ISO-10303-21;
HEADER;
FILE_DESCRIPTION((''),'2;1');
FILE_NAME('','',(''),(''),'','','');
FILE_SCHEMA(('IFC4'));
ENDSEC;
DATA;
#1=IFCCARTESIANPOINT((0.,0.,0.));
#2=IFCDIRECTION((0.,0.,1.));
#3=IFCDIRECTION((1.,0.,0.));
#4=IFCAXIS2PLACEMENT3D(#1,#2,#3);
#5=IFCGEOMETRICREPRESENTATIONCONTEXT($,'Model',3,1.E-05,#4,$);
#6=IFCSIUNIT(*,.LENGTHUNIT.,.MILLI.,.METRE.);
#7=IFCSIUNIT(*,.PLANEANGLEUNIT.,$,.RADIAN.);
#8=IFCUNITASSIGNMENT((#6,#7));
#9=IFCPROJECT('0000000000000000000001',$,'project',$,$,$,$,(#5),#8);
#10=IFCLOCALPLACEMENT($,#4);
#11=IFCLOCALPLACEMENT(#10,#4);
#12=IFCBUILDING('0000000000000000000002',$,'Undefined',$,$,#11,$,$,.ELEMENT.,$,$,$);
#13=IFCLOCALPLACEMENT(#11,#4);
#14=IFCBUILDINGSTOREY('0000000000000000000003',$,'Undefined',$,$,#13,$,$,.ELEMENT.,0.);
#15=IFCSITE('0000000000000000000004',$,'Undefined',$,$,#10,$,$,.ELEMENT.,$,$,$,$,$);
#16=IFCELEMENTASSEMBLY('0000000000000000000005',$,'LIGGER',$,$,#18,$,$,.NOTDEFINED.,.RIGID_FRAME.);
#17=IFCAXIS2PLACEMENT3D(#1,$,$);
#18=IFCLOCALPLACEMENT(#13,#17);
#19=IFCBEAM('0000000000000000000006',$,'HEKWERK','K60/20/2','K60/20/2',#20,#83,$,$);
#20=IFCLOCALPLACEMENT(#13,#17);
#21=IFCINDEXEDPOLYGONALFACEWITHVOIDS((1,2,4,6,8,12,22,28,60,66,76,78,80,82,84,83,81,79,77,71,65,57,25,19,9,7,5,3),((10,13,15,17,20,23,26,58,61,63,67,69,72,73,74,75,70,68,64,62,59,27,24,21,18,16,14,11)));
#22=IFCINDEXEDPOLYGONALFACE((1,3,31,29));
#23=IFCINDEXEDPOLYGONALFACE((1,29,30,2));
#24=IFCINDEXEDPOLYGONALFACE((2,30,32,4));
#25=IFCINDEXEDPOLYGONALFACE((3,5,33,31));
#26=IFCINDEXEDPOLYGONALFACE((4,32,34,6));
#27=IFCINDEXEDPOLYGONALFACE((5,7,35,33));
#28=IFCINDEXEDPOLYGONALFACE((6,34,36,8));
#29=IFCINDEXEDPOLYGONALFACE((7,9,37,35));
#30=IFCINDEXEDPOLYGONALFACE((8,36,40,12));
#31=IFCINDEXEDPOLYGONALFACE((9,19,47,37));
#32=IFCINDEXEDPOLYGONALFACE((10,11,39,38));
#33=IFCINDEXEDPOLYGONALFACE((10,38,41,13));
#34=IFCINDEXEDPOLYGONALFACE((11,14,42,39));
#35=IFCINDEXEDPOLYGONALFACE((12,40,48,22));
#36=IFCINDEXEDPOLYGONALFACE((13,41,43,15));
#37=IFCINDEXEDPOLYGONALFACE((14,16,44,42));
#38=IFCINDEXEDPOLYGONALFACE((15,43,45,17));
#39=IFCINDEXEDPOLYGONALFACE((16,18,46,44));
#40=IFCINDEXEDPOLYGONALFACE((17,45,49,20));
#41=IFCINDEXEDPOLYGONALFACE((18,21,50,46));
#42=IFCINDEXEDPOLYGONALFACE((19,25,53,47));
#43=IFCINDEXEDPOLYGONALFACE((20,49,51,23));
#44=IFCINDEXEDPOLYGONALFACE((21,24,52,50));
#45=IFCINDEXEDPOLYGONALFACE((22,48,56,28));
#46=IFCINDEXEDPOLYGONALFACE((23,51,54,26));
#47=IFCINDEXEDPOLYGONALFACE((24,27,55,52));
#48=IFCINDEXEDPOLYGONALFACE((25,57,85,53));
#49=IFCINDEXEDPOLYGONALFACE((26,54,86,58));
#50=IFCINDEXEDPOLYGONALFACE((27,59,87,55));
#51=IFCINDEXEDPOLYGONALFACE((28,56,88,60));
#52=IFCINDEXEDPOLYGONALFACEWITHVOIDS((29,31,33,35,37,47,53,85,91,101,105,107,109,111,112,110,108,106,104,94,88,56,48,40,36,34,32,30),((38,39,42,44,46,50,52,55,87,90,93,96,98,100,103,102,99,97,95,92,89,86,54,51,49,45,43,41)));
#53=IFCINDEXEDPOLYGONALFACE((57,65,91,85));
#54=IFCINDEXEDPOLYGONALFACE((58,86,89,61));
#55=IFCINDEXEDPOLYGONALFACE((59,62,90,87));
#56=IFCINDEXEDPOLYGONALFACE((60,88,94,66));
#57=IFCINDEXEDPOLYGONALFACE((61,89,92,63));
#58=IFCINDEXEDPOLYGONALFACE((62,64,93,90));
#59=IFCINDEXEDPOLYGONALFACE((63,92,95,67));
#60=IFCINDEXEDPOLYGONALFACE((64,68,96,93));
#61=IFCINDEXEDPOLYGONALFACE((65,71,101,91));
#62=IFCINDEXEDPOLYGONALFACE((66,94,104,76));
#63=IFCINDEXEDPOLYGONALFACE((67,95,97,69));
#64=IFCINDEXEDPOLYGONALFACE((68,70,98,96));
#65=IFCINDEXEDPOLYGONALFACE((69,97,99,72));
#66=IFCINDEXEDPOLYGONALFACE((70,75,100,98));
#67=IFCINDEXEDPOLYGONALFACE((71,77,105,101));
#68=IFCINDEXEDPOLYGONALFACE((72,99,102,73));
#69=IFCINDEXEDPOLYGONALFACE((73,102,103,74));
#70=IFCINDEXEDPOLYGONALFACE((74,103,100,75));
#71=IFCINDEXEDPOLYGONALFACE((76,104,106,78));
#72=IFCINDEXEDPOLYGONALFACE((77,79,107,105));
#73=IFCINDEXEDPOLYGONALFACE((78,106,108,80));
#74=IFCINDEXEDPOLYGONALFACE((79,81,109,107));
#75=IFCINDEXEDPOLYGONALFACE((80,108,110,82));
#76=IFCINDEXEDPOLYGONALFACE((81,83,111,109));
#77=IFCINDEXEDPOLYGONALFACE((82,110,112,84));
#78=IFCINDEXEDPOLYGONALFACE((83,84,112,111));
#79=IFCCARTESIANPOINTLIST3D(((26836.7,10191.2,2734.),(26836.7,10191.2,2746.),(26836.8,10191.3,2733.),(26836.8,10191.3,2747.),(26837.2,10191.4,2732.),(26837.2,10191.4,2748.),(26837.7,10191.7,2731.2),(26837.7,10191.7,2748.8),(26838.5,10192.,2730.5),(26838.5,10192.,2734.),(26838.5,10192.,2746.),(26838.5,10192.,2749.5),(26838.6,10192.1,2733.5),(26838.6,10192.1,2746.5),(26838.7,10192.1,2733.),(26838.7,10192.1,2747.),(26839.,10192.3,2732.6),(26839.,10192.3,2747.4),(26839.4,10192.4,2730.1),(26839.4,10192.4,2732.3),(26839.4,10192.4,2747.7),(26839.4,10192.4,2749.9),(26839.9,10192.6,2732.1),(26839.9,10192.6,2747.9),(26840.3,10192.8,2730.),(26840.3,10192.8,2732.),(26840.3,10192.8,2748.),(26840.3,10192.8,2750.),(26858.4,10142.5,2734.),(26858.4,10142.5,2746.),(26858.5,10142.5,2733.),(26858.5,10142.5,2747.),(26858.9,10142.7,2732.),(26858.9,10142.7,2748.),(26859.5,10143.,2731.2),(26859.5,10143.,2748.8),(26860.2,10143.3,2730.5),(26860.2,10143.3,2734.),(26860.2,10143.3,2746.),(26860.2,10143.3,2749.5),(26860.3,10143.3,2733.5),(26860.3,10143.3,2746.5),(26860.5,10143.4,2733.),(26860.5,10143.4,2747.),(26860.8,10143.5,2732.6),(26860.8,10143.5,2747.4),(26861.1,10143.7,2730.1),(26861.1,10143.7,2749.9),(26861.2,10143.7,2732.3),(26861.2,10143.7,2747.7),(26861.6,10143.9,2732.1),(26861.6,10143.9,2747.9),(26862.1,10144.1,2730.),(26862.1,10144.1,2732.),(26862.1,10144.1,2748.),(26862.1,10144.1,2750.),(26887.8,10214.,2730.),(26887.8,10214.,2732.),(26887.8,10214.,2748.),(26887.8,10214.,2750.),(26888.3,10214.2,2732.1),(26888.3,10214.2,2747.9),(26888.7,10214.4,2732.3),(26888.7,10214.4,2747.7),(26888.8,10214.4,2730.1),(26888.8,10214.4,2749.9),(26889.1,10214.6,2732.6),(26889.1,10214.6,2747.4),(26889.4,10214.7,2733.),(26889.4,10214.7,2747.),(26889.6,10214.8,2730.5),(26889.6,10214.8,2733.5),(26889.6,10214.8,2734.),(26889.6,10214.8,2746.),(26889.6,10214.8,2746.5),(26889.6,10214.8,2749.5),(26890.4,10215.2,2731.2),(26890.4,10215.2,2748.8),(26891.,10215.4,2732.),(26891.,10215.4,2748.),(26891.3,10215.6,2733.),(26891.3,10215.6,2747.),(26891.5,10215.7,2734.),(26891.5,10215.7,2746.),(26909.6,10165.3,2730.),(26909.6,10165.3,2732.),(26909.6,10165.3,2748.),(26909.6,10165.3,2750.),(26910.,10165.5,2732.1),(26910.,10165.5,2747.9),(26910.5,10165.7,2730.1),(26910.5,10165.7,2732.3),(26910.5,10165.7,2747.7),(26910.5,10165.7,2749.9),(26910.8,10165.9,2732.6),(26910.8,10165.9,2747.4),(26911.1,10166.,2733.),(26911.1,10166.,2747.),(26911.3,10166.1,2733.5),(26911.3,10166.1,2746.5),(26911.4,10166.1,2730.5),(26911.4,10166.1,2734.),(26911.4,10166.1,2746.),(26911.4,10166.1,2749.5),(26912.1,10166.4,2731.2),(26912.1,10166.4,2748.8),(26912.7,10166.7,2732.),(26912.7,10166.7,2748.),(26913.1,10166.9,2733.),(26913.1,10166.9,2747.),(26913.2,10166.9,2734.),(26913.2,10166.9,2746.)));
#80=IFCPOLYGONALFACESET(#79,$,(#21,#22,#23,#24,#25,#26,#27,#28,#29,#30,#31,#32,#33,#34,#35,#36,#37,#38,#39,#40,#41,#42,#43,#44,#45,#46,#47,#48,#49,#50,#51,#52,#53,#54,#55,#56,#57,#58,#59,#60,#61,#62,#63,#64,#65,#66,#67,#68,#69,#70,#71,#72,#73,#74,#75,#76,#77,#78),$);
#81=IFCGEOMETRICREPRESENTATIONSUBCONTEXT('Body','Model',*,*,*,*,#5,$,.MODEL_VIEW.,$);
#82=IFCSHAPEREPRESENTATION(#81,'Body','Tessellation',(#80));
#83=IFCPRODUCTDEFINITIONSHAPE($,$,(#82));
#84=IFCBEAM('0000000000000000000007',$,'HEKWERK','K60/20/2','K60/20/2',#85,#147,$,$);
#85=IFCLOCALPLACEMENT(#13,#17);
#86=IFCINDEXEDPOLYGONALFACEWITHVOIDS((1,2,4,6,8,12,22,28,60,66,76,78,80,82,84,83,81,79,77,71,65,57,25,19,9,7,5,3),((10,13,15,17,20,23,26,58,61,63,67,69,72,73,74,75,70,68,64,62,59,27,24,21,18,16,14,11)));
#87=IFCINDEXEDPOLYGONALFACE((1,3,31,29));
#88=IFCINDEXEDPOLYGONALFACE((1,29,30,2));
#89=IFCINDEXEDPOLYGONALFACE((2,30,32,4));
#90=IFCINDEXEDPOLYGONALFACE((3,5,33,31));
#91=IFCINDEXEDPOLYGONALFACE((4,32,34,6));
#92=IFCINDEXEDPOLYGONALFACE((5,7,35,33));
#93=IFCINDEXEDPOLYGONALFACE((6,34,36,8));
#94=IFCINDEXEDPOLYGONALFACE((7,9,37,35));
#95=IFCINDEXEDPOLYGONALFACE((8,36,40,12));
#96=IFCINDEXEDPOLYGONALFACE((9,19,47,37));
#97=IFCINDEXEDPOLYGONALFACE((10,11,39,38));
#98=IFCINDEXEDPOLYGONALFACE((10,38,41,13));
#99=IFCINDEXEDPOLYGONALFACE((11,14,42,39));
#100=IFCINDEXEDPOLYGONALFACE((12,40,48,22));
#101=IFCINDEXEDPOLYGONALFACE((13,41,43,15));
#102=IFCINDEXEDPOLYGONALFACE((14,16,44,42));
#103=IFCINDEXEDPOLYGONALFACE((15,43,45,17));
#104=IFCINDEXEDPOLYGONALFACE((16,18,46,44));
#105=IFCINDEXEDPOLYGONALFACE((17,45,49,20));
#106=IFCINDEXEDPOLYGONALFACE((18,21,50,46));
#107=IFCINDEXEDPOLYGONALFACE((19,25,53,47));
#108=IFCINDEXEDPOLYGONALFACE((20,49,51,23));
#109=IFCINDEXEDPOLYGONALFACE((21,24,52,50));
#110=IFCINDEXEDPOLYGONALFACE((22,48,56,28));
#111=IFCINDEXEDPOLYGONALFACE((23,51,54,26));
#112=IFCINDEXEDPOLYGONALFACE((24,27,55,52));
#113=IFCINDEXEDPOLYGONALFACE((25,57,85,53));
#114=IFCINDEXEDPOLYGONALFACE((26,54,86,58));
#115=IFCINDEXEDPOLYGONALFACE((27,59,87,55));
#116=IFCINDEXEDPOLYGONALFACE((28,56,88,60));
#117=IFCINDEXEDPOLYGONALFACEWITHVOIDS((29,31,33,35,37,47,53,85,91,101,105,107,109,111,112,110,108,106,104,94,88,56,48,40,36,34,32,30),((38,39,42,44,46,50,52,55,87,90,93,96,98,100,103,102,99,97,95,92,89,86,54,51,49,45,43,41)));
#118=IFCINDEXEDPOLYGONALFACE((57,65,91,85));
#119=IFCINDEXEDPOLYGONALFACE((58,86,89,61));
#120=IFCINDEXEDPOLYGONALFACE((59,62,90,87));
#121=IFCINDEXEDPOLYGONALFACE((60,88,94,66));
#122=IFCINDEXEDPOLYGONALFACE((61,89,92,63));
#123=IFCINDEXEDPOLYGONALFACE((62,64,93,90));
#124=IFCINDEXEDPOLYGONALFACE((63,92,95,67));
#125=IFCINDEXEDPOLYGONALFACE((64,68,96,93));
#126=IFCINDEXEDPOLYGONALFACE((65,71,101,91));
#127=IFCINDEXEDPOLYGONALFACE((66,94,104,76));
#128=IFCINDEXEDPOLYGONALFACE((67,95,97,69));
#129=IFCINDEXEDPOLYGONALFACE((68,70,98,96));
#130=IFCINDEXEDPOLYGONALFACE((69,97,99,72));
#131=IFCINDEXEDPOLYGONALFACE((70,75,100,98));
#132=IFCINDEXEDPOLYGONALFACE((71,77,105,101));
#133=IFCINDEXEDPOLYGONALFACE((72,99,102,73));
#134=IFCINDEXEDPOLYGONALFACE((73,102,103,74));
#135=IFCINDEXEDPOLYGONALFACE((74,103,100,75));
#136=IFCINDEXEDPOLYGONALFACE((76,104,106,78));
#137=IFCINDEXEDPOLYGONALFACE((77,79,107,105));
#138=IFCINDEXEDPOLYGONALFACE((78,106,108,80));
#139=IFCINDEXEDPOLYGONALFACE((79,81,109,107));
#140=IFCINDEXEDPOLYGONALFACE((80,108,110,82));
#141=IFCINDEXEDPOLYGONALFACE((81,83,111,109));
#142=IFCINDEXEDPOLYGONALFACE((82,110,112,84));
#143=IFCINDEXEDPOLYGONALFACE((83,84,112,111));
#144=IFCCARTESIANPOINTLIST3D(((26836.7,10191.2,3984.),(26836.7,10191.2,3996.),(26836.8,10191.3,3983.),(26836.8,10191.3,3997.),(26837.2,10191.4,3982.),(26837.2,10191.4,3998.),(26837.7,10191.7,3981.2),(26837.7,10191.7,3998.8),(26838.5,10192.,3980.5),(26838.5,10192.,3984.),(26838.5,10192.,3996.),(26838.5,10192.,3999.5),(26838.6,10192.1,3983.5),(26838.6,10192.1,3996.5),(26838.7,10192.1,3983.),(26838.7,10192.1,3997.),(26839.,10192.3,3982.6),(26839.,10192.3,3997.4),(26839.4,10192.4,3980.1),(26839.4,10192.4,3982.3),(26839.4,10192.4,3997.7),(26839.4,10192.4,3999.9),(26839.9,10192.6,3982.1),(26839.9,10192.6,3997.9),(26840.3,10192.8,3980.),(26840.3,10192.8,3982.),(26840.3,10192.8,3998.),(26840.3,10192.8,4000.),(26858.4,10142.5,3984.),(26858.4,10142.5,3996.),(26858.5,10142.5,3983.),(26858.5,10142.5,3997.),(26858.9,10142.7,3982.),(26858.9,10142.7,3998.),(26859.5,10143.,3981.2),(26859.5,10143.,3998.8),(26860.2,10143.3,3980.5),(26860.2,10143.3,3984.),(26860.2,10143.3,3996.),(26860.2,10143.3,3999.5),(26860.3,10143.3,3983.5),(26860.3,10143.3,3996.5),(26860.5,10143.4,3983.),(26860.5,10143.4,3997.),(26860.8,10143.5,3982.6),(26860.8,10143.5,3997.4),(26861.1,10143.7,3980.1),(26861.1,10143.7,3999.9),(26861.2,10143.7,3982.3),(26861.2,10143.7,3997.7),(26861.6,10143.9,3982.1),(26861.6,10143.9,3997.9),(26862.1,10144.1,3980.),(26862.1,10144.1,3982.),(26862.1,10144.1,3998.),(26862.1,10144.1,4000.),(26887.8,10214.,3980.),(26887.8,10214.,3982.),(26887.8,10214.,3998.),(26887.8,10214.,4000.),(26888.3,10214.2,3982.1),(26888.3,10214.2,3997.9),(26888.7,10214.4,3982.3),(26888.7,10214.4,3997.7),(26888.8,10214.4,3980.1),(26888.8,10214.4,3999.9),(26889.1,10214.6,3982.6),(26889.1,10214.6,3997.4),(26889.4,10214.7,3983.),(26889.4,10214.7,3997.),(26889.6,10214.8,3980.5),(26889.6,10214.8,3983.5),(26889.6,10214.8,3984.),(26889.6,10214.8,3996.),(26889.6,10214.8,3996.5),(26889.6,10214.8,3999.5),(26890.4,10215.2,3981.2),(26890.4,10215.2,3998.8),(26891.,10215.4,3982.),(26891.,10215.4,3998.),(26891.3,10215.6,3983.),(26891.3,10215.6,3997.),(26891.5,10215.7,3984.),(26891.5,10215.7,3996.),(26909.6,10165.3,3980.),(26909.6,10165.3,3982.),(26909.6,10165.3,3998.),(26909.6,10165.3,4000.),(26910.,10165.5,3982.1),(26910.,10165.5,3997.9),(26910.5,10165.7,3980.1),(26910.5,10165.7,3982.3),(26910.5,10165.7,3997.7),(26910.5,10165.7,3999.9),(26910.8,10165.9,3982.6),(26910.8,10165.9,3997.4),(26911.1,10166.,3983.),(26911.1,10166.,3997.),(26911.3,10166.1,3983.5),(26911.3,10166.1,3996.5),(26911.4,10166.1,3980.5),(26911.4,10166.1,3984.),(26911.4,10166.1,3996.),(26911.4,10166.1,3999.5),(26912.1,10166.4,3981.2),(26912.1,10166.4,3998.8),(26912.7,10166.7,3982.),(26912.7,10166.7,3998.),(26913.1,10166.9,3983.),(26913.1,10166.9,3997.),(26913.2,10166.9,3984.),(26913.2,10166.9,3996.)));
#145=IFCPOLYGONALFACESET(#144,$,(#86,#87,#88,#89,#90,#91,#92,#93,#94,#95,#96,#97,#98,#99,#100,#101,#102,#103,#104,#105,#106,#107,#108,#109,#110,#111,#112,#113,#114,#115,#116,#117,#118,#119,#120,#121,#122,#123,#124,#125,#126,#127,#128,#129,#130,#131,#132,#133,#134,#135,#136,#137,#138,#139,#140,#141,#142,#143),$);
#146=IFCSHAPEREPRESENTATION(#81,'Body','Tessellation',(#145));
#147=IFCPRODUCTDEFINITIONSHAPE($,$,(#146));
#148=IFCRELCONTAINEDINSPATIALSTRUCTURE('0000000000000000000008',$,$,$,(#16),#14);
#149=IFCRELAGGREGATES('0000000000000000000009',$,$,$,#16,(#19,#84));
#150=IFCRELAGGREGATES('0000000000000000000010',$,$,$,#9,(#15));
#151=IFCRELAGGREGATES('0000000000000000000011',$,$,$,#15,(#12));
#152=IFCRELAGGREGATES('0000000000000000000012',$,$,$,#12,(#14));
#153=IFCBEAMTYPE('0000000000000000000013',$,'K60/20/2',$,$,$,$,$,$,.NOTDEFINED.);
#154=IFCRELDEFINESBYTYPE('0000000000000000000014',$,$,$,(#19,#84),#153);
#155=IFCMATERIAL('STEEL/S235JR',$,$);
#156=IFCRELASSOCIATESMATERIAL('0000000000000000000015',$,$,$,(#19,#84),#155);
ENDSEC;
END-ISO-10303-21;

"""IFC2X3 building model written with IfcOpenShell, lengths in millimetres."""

from ifc_helpers import new_model, si_unit, frame, origin_with_axes, origin_2d_with_axis, place, context, subcontext, project, spatial, hollow_rectangle, extrude, material, type_object, element, aggregate, save


model = new_model("IFC2X3")

# Units and contexts
model_context = context("Model", 3, precision=1e-05, world=origin_with_axes())
body_context = subcontext(model_context, "Body", "Model", "MODEL_VIEW")
ifc_project = project(units=[si_unit("LENGTHUNIT", "METRE", prefix="MILLI"), si_unit("PLANEANGLEUNIT", "RADIAN")], contexts=[model_context])

# Site, building, storey
site_placement = place(None, origin_with_axes())
site = spatial("IfcSite", under=ifc_project, at=site_placement, Name="Undefined", CompositionType="ELEMENT")
building_placement = place(site_placement, origin_with_axes())
building = spatial("IfcBuilding", under=site, at=building_placement, Name="Undefined", CompositionType="ELEMENT")
storey_placement = place(building_placement, origin_with_axes())
storey = spatial("IfcBuildingStorey", under=building, at=storey_placement, Name="Undefined", CompositionType="ELEMENT", Elevation=0.0)

# Element assembly, beams
ifc_material_1 = material(Name="STEEL/S235JR")
beam_type_1 = type_object("IfcBeamType", Name="K60/20/2", PredefinedType="NOTDEFINED")
assembly_1_placement = place(storey_placement, origin_with_axes())
assembly_1 = element("IfcElementAssembly", 1, at=assembly_1_placement, inside=storey, Name="LIGGER", AssemblyPlace="NOTDEFINED", PredefinedType="RIGID_FRAME")
beam_1_placement = place(assembly_1_placement, frame((26864.1, 10203.4, 2740.0), z_axis=(0.913309, 0.407268, 0.0), x_axis=(0.407268, -0.913309, 0.0)))
beam_1 = element("IfcBeam", 2, at=beam_1_placement, type_object=beam_type_1, material=ifc_material_1, Name="HEKWERK", Description="K60/20/2", ObjectType="K60/20/2", context=body_context, shape_type="SweptSolid", body=[
    extrude(hollow_rectangle(XDim=20.0, YDim=60.0, WallThickness=2.0, InnerFilletRadius=2.0, OuterFilletRadius=4.0, at=origin_2d_with_axis()), frame((53.4, 0.0, 0.0), z_axis=(-1.0, 0.0, 0.0), x_axis=(0.0, -1.0, 0.0)), (0.0, 0.0, 1.0), 53.4),
])
beam_2_placement = place(assembly_1_placement, frame((26864.1, 10203.4, 3990.0), z_axis=(0.913309, 0.407268, 0.0), x_axis=(0.407268, -0.913309, 0.0)))
beam_2 = element("IfcBeam", 3, at=beam_2_placement, type_object=beam_type_1, material=ifc_material_1, Name="HEKWERK", Description="K60/20/2", ObjectType="K60/20/2", context=body_context, shape_type="SweptSolid", body=[
    extrude(hollow_rectangle(XDim=20.0, YDim=60.0, WallThickness=2.0, InnerFilletRadius=2.0, OuterFilletRadius=4.0, at=origin_2d_with_axis()), frame((53.4, 0.0, 0.0), z_axis=(-1.0, 0.0, 0.0), x_axis=(0.0, -1.0, 0.0)), (0.0, 0.0, 1.0), 53.4),
])

aggregate(assembly_1, [beam_1, beam_2])

save(model, "model.ifc")
